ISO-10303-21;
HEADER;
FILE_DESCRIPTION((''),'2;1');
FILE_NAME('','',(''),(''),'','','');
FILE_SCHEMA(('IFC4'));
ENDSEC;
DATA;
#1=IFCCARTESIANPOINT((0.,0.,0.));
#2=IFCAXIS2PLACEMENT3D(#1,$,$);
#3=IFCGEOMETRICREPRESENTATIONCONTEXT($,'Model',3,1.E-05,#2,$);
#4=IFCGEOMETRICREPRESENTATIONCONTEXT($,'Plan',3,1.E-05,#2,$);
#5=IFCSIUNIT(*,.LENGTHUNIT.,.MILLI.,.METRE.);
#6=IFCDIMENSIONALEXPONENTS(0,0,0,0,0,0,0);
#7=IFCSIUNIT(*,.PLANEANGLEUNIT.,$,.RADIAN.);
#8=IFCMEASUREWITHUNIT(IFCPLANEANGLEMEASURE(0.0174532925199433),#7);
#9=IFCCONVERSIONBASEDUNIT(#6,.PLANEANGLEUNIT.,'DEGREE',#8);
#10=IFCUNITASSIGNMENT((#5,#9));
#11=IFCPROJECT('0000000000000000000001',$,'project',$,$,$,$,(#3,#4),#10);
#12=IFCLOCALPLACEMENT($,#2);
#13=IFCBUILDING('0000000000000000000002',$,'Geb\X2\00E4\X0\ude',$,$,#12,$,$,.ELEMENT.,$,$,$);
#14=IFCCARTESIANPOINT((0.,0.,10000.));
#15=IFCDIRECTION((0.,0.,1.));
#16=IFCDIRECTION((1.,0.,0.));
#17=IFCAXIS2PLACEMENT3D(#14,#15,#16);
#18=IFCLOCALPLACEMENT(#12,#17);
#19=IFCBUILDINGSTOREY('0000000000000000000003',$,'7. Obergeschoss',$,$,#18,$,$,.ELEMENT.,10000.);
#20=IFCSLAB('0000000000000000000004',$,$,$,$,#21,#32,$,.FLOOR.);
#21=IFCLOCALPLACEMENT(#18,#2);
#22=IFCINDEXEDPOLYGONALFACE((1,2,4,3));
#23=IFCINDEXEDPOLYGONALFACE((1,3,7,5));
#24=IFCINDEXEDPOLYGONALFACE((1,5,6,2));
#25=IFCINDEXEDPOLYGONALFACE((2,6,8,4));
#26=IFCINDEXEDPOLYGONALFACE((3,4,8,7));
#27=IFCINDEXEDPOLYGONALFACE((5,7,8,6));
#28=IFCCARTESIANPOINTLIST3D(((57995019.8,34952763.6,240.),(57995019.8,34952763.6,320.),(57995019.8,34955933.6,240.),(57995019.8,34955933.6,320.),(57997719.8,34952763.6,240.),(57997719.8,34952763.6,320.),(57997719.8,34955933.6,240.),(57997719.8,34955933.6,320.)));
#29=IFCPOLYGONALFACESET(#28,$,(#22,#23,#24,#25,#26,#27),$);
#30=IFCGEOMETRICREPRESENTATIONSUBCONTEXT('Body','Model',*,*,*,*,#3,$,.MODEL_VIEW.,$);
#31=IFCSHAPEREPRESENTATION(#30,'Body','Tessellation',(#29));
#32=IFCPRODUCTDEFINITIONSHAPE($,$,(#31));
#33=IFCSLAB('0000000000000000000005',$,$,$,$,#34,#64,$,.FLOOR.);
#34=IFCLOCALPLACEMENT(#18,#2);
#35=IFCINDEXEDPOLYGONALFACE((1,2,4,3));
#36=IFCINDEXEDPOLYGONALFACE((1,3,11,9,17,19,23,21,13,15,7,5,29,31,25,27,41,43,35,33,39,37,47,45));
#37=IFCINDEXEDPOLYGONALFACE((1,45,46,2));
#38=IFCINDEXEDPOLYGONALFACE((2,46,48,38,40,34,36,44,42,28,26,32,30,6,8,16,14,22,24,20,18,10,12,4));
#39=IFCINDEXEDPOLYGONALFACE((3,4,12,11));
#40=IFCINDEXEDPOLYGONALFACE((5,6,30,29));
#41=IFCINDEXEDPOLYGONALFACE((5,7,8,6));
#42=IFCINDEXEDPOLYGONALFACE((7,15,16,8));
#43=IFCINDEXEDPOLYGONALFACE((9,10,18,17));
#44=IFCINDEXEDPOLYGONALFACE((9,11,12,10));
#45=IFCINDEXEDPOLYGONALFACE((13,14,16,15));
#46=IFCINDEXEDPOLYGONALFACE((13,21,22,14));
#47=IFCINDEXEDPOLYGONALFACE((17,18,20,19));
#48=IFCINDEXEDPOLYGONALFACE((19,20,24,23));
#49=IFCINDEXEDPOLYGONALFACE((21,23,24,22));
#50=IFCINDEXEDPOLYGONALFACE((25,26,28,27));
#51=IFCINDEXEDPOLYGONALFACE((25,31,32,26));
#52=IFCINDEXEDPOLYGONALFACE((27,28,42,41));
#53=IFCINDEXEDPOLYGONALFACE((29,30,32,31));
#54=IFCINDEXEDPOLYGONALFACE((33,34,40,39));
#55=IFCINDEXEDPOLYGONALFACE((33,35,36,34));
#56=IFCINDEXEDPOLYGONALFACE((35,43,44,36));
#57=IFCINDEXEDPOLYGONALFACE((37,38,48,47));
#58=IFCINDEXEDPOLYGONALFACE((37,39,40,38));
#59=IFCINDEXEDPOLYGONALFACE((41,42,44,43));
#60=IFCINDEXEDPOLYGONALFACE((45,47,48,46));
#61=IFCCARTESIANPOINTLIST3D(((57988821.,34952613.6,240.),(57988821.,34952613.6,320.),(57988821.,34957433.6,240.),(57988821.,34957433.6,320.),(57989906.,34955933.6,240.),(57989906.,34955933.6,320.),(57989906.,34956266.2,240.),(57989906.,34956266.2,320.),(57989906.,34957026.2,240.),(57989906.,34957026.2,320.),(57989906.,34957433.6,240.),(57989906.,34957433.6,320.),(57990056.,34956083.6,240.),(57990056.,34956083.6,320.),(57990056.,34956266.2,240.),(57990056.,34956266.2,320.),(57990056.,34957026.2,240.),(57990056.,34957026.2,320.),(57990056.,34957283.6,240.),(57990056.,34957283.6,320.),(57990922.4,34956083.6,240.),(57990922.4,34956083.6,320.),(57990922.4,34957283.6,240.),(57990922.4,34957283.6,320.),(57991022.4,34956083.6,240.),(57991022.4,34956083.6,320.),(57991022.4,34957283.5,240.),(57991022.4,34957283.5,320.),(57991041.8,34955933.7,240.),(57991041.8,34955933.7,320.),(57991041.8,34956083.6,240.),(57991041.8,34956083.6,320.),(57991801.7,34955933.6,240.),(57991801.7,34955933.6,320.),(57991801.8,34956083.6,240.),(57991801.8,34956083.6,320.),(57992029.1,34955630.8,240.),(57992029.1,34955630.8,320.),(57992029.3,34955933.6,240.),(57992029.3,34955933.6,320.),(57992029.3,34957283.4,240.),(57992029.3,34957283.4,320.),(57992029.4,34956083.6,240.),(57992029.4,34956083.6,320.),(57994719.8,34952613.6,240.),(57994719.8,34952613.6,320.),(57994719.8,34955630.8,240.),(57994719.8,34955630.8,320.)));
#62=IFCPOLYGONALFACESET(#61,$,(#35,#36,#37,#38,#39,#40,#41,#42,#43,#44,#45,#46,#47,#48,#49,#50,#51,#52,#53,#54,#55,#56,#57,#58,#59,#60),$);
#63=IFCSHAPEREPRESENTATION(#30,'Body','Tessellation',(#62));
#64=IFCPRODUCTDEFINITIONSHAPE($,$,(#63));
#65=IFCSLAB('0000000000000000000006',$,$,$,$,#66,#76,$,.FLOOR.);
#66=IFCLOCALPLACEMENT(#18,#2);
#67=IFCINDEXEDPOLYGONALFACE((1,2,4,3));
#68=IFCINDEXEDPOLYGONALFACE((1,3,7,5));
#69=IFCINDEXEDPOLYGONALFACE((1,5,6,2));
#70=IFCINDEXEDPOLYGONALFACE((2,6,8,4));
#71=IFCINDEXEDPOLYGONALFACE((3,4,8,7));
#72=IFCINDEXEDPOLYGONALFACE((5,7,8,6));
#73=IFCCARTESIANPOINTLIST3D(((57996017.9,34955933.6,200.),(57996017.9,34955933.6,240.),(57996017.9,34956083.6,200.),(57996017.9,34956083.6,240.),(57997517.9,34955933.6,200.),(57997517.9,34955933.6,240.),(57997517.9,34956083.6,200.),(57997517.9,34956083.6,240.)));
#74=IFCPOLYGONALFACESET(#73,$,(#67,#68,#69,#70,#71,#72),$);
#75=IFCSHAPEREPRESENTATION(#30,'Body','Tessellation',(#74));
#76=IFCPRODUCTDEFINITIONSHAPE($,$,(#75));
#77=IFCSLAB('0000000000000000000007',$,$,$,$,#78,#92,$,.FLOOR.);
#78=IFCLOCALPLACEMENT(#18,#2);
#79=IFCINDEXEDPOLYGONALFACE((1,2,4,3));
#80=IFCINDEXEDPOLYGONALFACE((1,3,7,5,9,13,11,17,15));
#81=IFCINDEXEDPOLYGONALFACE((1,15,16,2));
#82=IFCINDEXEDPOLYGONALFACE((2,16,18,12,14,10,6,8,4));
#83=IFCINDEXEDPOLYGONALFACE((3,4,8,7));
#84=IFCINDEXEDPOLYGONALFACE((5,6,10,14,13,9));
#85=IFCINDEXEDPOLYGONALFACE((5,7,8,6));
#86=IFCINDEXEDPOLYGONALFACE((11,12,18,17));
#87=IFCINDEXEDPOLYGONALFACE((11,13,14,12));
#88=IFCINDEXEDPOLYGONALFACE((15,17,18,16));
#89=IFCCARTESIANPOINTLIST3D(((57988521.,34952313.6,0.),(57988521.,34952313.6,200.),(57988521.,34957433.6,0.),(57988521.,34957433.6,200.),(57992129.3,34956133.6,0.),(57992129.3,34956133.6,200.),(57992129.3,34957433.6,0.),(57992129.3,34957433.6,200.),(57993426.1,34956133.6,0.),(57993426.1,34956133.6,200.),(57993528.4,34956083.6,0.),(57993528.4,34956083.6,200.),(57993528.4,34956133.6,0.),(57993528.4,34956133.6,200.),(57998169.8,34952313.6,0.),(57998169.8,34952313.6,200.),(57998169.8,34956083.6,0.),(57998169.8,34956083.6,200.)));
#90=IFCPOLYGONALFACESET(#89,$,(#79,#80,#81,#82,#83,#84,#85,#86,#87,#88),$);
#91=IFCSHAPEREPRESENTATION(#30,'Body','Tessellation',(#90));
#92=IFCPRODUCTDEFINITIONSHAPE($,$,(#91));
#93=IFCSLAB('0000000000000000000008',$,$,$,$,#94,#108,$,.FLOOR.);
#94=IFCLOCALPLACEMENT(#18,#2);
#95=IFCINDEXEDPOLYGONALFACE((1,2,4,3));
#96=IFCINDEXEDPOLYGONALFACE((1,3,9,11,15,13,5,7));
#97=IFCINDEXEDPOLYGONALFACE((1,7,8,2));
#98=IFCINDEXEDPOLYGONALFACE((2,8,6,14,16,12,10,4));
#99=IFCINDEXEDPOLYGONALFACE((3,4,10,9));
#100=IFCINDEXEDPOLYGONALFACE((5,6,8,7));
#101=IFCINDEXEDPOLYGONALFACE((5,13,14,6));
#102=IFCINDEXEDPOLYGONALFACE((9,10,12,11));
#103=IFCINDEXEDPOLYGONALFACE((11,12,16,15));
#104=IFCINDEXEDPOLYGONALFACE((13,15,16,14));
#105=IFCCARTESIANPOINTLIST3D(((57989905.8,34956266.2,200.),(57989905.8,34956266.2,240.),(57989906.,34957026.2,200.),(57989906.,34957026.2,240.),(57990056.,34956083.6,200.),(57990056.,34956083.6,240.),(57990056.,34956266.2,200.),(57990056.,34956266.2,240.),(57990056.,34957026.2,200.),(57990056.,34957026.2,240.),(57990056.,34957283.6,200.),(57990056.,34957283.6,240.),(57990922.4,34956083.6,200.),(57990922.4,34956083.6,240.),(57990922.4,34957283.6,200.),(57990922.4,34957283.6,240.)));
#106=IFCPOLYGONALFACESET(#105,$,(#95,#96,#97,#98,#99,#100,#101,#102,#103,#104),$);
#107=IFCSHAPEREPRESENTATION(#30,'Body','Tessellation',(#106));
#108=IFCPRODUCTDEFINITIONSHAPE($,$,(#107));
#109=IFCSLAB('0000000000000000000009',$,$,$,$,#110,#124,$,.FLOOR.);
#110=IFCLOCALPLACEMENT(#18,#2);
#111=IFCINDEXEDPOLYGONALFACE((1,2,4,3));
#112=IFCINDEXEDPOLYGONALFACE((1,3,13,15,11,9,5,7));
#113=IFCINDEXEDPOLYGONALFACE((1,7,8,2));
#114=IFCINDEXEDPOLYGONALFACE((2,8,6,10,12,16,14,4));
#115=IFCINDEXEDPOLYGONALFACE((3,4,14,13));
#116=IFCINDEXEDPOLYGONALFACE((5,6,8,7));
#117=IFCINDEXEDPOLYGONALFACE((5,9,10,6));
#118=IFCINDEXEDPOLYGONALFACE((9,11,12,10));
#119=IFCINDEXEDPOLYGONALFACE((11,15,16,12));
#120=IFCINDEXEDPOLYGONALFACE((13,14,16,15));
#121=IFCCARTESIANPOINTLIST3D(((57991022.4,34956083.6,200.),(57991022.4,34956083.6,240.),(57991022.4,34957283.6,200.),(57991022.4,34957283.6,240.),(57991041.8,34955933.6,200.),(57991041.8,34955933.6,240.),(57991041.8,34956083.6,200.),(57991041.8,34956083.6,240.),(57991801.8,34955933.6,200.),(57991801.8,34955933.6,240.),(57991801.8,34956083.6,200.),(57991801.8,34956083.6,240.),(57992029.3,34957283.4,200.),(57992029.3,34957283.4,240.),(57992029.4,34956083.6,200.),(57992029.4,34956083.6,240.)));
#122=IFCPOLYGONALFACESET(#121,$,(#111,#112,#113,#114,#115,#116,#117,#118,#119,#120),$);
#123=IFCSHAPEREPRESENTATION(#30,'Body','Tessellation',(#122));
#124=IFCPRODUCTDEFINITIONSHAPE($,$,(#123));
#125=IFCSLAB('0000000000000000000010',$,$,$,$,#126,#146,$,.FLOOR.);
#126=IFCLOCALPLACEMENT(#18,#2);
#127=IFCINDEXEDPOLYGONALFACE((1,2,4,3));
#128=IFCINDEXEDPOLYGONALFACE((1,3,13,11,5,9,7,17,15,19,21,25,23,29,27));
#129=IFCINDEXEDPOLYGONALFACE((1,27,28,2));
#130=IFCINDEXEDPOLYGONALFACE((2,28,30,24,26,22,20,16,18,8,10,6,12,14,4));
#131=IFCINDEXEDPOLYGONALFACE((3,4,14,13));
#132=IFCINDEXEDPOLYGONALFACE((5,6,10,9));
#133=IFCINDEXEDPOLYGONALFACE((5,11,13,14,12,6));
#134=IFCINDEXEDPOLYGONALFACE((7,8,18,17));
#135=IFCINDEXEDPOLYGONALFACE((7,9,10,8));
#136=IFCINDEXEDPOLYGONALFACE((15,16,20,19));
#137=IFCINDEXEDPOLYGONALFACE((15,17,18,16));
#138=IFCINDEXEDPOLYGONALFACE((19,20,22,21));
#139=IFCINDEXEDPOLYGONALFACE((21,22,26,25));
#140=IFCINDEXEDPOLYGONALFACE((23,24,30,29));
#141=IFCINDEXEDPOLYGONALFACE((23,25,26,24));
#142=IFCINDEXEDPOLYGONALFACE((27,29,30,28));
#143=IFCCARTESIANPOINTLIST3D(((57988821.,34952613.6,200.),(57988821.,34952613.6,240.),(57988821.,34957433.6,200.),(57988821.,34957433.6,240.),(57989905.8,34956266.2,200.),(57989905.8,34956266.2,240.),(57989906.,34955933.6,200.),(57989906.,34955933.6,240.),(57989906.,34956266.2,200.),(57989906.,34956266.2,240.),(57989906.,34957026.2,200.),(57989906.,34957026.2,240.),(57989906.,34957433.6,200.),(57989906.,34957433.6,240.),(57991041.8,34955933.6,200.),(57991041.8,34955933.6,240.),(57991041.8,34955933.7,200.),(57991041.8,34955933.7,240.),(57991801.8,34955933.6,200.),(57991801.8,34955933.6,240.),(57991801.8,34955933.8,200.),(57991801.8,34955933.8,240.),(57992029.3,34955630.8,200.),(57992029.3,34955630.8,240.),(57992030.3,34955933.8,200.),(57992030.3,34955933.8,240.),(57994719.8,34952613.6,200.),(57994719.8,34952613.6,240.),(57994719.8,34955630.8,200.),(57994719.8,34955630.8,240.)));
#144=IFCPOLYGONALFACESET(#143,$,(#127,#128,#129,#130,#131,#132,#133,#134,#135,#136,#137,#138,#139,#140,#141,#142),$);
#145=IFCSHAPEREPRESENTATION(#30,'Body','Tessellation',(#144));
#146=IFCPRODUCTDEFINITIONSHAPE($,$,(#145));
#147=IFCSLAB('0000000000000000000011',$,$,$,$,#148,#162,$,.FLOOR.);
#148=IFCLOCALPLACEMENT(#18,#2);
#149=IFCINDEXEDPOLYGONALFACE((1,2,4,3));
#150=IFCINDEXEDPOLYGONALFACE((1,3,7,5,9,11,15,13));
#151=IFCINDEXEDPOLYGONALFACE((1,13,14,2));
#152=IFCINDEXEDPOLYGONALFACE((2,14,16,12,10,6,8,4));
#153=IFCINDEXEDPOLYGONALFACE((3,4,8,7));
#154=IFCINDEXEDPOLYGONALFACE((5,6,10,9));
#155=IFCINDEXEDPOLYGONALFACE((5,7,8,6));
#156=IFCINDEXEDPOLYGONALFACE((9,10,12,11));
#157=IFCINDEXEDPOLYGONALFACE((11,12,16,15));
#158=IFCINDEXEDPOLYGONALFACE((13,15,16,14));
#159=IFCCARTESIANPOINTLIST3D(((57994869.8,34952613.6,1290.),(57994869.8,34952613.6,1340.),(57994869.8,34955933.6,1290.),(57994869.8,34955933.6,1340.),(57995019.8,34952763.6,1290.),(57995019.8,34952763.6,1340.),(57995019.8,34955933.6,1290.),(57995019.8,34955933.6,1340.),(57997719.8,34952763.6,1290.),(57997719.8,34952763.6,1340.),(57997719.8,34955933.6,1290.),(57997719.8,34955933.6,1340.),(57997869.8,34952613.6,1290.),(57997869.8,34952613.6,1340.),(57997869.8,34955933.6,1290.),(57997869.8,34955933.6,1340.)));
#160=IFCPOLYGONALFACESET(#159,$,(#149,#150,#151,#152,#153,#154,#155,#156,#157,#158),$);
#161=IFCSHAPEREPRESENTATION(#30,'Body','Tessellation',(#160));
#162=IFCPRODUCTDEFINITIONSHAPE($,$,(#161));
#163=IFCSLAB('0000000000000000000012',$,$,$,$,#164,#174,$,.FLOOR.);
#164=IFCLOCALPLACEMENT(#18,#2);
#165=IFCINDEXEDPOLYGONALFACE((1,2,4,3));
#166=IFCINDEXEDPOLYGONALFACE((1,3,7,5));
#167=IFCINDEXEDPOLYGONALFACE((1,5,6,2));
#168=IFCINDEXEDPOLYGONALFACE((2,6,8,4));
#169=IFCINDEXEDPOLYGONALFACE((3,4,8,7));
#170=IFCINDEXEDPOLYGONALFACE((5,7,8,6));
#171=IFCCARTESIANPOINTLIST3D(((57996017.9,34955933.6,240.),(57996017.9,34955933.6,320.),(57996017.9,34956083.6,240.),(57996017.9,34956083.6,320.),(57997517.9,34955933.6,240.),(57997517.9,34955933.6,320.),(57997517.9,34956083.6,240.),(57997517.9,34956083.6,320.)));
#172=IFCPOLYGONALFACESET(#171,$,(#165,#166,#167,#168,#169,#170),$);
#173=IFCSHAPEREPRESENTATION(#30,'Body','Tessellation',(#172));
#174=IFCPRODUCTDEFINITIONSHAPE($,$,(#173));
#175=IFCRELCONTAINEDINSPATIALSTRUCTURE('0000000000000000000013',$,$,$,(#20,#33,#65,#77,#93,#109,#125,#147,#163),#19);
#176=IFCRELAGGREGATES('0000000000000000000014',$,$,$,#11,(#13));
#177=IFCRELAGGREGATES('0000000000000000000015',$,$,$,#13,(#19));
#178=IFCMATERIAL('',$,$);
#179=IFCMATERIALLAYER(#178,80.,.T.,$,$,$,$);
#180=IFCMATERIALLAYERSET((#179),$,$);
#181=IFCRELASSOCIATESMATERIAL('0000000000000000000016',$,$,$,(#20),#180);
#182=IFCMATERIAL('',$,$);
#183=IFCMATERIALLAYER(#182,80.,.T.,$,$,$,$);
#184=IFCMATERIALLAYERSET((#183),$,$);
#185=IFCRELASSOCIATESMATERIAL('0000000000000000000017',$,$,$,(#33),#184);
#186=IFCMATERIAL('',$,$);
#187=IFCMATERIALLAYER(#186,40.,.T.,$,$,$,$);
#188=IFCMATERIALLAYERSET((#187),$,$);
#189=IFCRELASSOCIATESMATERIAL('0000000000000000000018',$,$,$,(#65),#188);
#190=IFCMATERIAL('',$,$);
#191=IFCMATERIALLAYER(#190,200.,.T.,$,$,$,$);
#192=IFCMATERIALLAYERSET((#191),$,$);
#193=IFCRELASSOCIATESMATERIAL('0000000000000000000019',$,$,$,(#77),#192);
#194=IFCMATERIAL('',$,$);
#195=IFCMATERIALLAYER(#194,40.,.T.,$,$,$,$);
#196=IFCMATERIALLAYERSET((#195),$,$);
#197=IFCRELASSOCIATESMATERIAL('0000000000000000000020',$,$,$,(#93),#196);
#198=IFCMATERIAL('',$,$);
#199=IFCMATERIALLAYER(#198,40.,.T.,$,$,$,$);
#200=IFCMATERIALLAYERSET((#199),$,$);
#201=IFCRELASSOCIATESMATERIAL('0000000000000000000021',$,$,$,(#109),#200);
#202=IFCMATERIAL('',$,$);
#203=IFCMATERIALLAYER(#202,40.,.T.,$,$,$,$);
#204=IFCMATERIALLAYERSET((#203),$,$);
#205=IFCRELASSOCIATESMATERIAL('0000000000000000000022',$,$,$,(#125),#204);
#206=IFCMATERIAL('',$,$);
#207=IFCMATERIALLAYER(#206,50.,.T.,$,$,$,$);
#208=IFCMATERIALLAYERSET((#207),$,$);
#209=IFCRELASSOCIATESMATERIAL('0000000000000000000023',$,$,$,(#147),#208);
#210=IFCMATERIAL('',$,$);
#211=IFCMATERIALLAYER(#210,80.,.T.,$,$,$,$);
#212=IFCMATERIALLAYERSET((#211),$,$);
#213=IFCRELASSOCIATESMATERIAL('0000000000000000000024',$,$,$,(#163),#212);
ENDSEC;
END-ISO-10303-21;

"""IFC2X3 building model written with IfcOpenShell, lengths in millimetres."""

from ifc_helpers import new_model, entity, si_unit, converted_unit, frame, frame_2d, origin, origin_with_axes, place, context, subcontext, project, spatial, polyline, rectangle, outline, extrude, material, layer, layer_set, layer_usage, element, save


model = new_model("IFC2X3")

# Units and contexts
model_context = context("Model", 3, precision=1e-05, world=origin())
plan_context = context("Plan", 3, precision=1e-05, world=origin())
body_context = subcontext(model_context, "Body", "Model", "MODEL_VIEW")
ifc_project = project(units=[si_unit("LENGTHUNIT", "METRE", prefix="MILLI"), converted_unit("PLANEANGLEUNIT", "DEGREE", entity("IfcPlaneAngleMeasure", 0.0174532925199433), si_unit("PLANEANGLEUNIT", "RADIAN"), dimensions=[0, 0, 0, 0, 0, 0, 0])], contexts=[model_context, plan_context])

# Building, storey
building_placement = place(None, origin())
building = spatial("IfcBuilding", under=ifc_project, at=building_placement, Name="Gebäude", CompositionType="ELEMENT")
storey_placement = place(building_placement, frame((0.0, 0.0, 10000.0), z_axis=(0.0, 0.0, 1.0), x_axis=(1.0, 0.0, 0.0)))
storey = spatial("IfcBuildingStorey", under=building, at=storey_placement, Name="7. Obergeschoss", CompositionType="ELEMENT", Elevation=10000.0)

# Slabs
ifc_material_1 = material(Name="")
ifc_layer_1 = layer(ifc_material_1, 80.0, ventilated=True)
ifc_layer_set_1 = layer_set([ifc_layer_1])
ifc_layer_usage_1 = layer_usage(ifc_layer_set_1, "AXIS3", "POSITIVE", 0.0)
slab_1_placement = place(storey_placement, frame((57995019.8, 34955933.6, 240.0), z_axis=(0.0, 0.0, 1.0), x_axis=(1.0, 0.0, 0.0)))
element("IfcSlab", 1, at=slab_1_placement, inside=storey, material=ifc_layer_usage_1, PredefinedType="FLOOR", context=body_context, shape_type="SweptSolid", body=[
    extrude(rectangle(XDim=3169.9, YDim=2700.0, at=frame_2d((1350.0, -1585.0), x_axis=(0.0, -1.0))), origin_with_axes(), (0.0, 0.0, 1.0), 80.0),
])
ifc_material_2 = material(Name="")
ifc_layer_2 = layer(ifc_material_2, 80.0, ventilated=True)
ifc_layer_set_2 = layer_set([ifc_layer_2])
ifc_layer_usage_2 = layer_usage(ifc_layer_set_2, "AXIS3", "POSITIVE", 0.0)
slab_2_placement = place(storey_placement, frame((57988821.0, 34952613.6, 240.0), z_axis=(0.0, 0.0, 1.0), x_axis=(1.0, 0.0, 0.0)))
element("IfcSlab", 2, at=slab_2_placement, inside=storey, material=ifc_layer_usage_2, PredefinedType="FLOOR", context=body_context, shape_type="SweptSolid", body=[
    extrude(outline(polyline([(0.0, 4819.9), (0.0, 0.0), (5898.8, 0.0), (5898.8, 3017.2), (3208.1, 3017.2), (3208.3, 3319.9), (2980.6, 3319.9), (2980.7, 3469.9), (3208.3, 3469.9), (3208.3, 4669.8), (2201.4, 4669.9), (2201.4, 3469.9), (2220.7, 3469.9), (2220.7, 3320.0), (1085.0, 3319.9), (1085.0, 3652.5), (1235.0, 3652.5), (1235.0, 3469.9), (2101.4, 3469.9), (2101.4, 4669.9), (1235.0, 4669.9), (1235.0, 4412.5), (1085.0, 4412.5), (1085.0, 4819.9), (0.0, 4819.9)])), origin_with_axes(), (0.0, 0.0, 1.0), 80.0),
])
ifc_material_3 = material(Name="")
ifc_layer_3 = layer(ifc_material_3, 40.0, ventilated=True)
ifc_layer_set_3 = layer_set([ifc_layer_3])
ifc_layer_usage_3 = layer_usage(ifc_layer_set_3, "AXIS3", "POSITIVE", 0.0)
slab_3_placement = place(storey_placement, frame((57996017.9, 34955933.6, 200.0), z_axis=(0.0, 0.0, 1.0), x_axis=(1.0, 0.0, 0.0)))
element("IfcSlab", 3, at=slab_3_placement, inside=storey, material=ifc_layer_usage_3, PredefinedType="FLOOR", context=body_context, shape_type="SweptSolid", body=[
    extrude(rectangle(XDim=1500.0, YDim=150.0, at=frame_2d((750.0, 75.0), x_axis=(1.0, 0.0))), origin_with_axes(), (0.0, 0.0, 1.0), 40.0),
])
ifc_material_4 = material(Name="")
ifc_layer_4 = layer(ifc_material_4, 200.0, ventilated=True)
ifc_layer_set_4 = layer_set([ifc_layer_4])
ifc_layer_usage_4 = layer_usage(ifc_layer_set_4, "AXIS3", "POSITIVE", 0.0)
slab_4_placement = place(storey_placement, frame((57988521.0, 34952313.6, 0.0), z_axis=(0.0, 0.0, 1.0), x_axis=(1.0, 0.0, 0.0)))
element("IfcSlab", 4, at=slab_4_placement, inside=storey, material=ifc_layer_usage_4, PredefinedType="FLOOR", context=body_context, shape_type="SweptSolid", body=[
    extrude(outline(polyline([(0.0, 5119.9), (0.0, 0.0), (9648.8, 0.0), (9648.8, 3769.9), (5007.4, 3769.9), (5007.4, 3819.9), (4905.0, 3819.9), (3608.3, 3819.9), (3608.3, 5119.9), (0.0, 5119.9)])), origin_with_axes(), (0.0, 0.0, 1.0), 200.0),
])
ifc_material_5 = material(Name="")
ifc_layer_5 = layer(ifc_material_5, 40.0, ventilated=True)
ifc_layer_set_5 = layer_set([ifc_layer_5])
ifc_layer_usage_5 = layer_usage(ifc_layer_set_5, "AXIS3", "POSITIVE", 0.0)
slab_5_placement = place(storey_placement, frame((57989905.8, 34956083.6, 200.0), z_axis=(0.0, 0.0, 1.0), x_axis=(1.0, 0.0, 0.0)))
element("IfcSlab", 5, at=slab_5_placement, inside=storey, material=ifc_layer_usage_5, PredefinedType="FLOOR", context=body_context, shape_type="SweptSolid", body=[
    extrude(outline(polyline([(0.0, 182.6), (150.3, 182.6), (150.3, 0.0), (1016.6, 0.0), (1016.6, 1200.0), (150.3, 1200.0), (150.3, 942.6), (0.3, 942.6), (0.0, 182.6)])), origin_with_axes(), (0.0, 0.0, 1.0), 40.0),
])
ifc_material_6 = material(Name="")
ifc_layer_6 = layer(ifc_material_6, 40.0, ventilated=True)
ifc_layer_set_6 = layer_set([ifc_layer_6])
ifc_layer_usage_6 = layer_usage(ifc_layer_set_6, "AXIS3", "POSITIVE", 0.0)
slab_6_placement = place(storey_placement, frame((57991022.4, 34955933.6, 200.0), z_axis=(0.0, 0.0, 1.0), x_axis=(1.0, 0.0, 0.0)))
element("IfcSlab", 6, at=slab_6_placement, inside=storey, material=ifc_layer_usage_6, PredefinedType="FLOOR", context=body_context, shape_type="SweptSolid", body=[
    extrude(outline(polyline([(0.0, 149.9), (19.4, 149.9), (19.4, 0.0), (779.4, 0.0), (779.4, 150.0), (1007.0, 149.9), (1006.9, 1349.8), (0.0, 1349.9), (0.0, 149.9)])), origin_with_axes(), (0.0, 0.0, 1.0), 40.0),
])
ifc_material_7 = material(Name="")
ifc_layer_7 = layer(ifc_material_7, 40.0, ventilated=True)
ifc_layer_set_7 = layer_set([ifc_layer_7])
ifc_layer_usage_7 = layer_usage(ifc_layer_set_7, "AXIS3", "POSITIVE", 0.0)
slab_7_placement = place(storey_placement, frame((57988821.0, 34952613.6, 200.0), z_axis=(0.0, 0.0, 1.0), x_axis=(1.0, 0.0, 0.0)))
element("IfcSlab", 7, at=slab_7_placement, inside=storey, material=ifc_layer_usage_7, PredefinedType="FLOOR", context=body_context, shape_type="SweptSolid", body=[
    extrude(outline(polyline([(0.0, 0.0), (5898.8, 0.0), (5898.8, 3017.2), (3208.3, 3017.2), (3209.3, 3320.1), (2980.7, 3320.1), (2980.7, 3320.0), (2220.7, 3320.0), (2220.7, 3320.0), (1085.0, 3319.9), (1085.0, 3652.5), (1084.7, 3652.5), (1085.0, 4412.5), (1085.0, 4820.0), (0.0, 4819.9), (0.0, 0.0)])), origin_with_axes(), (0.0, 0.0, 1.0), 40.0),
])
ifc_material_8 = material(Name="")
ifc_layer_8 = layer(ifc_material_8, 50.0, ventilated=True)
ifc_layer_set_8 = layer_set([ifc_layer_8])
ifc_layer_usage_8 = layer_usage(ifc_layer_set_8, "AXIS3", "POSITIVE", 0.0)
slab_8_placement = place(storey_placement, frame((57994869.8, 34952613.6, 1290.0), z_axis=(0.0, 0.0, 1.0), x_axis=(1.0, 0.0, 0.0)))
element("IfcSlab", 8, at=slab_8_placement, inside=storey, material=ifc_layer_usage_8, PredefinedType="FLOOR", context=body_context, shape_type="SweptSolid", body=[
    extrude(outline(polyline([(150.0, 3319.9), (0.0, 3319.9), (0.0, 0.0), (3000.0, 0.0), (3000.0, 3319.9), (2850.0, 3319.9), (2850.0, 150.0), (150.0, 150.0), (150.0, 3319.9)])), origin_with_axes(), (0.0, 0.0, 1.0), 50.0),
])
ifc_material_9 = material(Name="")
ifc_layer_9 = layer(ifc_material_9, 80.0, ventilated=True)
ifc_layer_set_9 = layer_set([ifc_layer_9])
ifc_layer_usage_9 = layer_usage(ifc_layer_set_9, "AXIS3", "POSITIVE", 0.0)
slab_9_placement = place(storey_placement, frame((57996017.9, 34955933.6, 240.0), z_axis=(0.0, 0.0, 1.0), x_axis=(1.0, 0.0, 0.0)))
element("IfcSlab", 9, at=slab_9_placement, inside=storey, material=ifc_layer_usage_9, PredefinedType="FLOOR", context=body_context, shape_type="SweptSolid", body=[
    extrude(rectangle(XDim=1500.0, YDim=150.0, at=frame_2d((750.0, 75.0), x_axis=(1.0, 0.0))), origin_with_axes(), (0.0, 0.0, 1.0), 80.0),
])

save(model, "model.ifc")
